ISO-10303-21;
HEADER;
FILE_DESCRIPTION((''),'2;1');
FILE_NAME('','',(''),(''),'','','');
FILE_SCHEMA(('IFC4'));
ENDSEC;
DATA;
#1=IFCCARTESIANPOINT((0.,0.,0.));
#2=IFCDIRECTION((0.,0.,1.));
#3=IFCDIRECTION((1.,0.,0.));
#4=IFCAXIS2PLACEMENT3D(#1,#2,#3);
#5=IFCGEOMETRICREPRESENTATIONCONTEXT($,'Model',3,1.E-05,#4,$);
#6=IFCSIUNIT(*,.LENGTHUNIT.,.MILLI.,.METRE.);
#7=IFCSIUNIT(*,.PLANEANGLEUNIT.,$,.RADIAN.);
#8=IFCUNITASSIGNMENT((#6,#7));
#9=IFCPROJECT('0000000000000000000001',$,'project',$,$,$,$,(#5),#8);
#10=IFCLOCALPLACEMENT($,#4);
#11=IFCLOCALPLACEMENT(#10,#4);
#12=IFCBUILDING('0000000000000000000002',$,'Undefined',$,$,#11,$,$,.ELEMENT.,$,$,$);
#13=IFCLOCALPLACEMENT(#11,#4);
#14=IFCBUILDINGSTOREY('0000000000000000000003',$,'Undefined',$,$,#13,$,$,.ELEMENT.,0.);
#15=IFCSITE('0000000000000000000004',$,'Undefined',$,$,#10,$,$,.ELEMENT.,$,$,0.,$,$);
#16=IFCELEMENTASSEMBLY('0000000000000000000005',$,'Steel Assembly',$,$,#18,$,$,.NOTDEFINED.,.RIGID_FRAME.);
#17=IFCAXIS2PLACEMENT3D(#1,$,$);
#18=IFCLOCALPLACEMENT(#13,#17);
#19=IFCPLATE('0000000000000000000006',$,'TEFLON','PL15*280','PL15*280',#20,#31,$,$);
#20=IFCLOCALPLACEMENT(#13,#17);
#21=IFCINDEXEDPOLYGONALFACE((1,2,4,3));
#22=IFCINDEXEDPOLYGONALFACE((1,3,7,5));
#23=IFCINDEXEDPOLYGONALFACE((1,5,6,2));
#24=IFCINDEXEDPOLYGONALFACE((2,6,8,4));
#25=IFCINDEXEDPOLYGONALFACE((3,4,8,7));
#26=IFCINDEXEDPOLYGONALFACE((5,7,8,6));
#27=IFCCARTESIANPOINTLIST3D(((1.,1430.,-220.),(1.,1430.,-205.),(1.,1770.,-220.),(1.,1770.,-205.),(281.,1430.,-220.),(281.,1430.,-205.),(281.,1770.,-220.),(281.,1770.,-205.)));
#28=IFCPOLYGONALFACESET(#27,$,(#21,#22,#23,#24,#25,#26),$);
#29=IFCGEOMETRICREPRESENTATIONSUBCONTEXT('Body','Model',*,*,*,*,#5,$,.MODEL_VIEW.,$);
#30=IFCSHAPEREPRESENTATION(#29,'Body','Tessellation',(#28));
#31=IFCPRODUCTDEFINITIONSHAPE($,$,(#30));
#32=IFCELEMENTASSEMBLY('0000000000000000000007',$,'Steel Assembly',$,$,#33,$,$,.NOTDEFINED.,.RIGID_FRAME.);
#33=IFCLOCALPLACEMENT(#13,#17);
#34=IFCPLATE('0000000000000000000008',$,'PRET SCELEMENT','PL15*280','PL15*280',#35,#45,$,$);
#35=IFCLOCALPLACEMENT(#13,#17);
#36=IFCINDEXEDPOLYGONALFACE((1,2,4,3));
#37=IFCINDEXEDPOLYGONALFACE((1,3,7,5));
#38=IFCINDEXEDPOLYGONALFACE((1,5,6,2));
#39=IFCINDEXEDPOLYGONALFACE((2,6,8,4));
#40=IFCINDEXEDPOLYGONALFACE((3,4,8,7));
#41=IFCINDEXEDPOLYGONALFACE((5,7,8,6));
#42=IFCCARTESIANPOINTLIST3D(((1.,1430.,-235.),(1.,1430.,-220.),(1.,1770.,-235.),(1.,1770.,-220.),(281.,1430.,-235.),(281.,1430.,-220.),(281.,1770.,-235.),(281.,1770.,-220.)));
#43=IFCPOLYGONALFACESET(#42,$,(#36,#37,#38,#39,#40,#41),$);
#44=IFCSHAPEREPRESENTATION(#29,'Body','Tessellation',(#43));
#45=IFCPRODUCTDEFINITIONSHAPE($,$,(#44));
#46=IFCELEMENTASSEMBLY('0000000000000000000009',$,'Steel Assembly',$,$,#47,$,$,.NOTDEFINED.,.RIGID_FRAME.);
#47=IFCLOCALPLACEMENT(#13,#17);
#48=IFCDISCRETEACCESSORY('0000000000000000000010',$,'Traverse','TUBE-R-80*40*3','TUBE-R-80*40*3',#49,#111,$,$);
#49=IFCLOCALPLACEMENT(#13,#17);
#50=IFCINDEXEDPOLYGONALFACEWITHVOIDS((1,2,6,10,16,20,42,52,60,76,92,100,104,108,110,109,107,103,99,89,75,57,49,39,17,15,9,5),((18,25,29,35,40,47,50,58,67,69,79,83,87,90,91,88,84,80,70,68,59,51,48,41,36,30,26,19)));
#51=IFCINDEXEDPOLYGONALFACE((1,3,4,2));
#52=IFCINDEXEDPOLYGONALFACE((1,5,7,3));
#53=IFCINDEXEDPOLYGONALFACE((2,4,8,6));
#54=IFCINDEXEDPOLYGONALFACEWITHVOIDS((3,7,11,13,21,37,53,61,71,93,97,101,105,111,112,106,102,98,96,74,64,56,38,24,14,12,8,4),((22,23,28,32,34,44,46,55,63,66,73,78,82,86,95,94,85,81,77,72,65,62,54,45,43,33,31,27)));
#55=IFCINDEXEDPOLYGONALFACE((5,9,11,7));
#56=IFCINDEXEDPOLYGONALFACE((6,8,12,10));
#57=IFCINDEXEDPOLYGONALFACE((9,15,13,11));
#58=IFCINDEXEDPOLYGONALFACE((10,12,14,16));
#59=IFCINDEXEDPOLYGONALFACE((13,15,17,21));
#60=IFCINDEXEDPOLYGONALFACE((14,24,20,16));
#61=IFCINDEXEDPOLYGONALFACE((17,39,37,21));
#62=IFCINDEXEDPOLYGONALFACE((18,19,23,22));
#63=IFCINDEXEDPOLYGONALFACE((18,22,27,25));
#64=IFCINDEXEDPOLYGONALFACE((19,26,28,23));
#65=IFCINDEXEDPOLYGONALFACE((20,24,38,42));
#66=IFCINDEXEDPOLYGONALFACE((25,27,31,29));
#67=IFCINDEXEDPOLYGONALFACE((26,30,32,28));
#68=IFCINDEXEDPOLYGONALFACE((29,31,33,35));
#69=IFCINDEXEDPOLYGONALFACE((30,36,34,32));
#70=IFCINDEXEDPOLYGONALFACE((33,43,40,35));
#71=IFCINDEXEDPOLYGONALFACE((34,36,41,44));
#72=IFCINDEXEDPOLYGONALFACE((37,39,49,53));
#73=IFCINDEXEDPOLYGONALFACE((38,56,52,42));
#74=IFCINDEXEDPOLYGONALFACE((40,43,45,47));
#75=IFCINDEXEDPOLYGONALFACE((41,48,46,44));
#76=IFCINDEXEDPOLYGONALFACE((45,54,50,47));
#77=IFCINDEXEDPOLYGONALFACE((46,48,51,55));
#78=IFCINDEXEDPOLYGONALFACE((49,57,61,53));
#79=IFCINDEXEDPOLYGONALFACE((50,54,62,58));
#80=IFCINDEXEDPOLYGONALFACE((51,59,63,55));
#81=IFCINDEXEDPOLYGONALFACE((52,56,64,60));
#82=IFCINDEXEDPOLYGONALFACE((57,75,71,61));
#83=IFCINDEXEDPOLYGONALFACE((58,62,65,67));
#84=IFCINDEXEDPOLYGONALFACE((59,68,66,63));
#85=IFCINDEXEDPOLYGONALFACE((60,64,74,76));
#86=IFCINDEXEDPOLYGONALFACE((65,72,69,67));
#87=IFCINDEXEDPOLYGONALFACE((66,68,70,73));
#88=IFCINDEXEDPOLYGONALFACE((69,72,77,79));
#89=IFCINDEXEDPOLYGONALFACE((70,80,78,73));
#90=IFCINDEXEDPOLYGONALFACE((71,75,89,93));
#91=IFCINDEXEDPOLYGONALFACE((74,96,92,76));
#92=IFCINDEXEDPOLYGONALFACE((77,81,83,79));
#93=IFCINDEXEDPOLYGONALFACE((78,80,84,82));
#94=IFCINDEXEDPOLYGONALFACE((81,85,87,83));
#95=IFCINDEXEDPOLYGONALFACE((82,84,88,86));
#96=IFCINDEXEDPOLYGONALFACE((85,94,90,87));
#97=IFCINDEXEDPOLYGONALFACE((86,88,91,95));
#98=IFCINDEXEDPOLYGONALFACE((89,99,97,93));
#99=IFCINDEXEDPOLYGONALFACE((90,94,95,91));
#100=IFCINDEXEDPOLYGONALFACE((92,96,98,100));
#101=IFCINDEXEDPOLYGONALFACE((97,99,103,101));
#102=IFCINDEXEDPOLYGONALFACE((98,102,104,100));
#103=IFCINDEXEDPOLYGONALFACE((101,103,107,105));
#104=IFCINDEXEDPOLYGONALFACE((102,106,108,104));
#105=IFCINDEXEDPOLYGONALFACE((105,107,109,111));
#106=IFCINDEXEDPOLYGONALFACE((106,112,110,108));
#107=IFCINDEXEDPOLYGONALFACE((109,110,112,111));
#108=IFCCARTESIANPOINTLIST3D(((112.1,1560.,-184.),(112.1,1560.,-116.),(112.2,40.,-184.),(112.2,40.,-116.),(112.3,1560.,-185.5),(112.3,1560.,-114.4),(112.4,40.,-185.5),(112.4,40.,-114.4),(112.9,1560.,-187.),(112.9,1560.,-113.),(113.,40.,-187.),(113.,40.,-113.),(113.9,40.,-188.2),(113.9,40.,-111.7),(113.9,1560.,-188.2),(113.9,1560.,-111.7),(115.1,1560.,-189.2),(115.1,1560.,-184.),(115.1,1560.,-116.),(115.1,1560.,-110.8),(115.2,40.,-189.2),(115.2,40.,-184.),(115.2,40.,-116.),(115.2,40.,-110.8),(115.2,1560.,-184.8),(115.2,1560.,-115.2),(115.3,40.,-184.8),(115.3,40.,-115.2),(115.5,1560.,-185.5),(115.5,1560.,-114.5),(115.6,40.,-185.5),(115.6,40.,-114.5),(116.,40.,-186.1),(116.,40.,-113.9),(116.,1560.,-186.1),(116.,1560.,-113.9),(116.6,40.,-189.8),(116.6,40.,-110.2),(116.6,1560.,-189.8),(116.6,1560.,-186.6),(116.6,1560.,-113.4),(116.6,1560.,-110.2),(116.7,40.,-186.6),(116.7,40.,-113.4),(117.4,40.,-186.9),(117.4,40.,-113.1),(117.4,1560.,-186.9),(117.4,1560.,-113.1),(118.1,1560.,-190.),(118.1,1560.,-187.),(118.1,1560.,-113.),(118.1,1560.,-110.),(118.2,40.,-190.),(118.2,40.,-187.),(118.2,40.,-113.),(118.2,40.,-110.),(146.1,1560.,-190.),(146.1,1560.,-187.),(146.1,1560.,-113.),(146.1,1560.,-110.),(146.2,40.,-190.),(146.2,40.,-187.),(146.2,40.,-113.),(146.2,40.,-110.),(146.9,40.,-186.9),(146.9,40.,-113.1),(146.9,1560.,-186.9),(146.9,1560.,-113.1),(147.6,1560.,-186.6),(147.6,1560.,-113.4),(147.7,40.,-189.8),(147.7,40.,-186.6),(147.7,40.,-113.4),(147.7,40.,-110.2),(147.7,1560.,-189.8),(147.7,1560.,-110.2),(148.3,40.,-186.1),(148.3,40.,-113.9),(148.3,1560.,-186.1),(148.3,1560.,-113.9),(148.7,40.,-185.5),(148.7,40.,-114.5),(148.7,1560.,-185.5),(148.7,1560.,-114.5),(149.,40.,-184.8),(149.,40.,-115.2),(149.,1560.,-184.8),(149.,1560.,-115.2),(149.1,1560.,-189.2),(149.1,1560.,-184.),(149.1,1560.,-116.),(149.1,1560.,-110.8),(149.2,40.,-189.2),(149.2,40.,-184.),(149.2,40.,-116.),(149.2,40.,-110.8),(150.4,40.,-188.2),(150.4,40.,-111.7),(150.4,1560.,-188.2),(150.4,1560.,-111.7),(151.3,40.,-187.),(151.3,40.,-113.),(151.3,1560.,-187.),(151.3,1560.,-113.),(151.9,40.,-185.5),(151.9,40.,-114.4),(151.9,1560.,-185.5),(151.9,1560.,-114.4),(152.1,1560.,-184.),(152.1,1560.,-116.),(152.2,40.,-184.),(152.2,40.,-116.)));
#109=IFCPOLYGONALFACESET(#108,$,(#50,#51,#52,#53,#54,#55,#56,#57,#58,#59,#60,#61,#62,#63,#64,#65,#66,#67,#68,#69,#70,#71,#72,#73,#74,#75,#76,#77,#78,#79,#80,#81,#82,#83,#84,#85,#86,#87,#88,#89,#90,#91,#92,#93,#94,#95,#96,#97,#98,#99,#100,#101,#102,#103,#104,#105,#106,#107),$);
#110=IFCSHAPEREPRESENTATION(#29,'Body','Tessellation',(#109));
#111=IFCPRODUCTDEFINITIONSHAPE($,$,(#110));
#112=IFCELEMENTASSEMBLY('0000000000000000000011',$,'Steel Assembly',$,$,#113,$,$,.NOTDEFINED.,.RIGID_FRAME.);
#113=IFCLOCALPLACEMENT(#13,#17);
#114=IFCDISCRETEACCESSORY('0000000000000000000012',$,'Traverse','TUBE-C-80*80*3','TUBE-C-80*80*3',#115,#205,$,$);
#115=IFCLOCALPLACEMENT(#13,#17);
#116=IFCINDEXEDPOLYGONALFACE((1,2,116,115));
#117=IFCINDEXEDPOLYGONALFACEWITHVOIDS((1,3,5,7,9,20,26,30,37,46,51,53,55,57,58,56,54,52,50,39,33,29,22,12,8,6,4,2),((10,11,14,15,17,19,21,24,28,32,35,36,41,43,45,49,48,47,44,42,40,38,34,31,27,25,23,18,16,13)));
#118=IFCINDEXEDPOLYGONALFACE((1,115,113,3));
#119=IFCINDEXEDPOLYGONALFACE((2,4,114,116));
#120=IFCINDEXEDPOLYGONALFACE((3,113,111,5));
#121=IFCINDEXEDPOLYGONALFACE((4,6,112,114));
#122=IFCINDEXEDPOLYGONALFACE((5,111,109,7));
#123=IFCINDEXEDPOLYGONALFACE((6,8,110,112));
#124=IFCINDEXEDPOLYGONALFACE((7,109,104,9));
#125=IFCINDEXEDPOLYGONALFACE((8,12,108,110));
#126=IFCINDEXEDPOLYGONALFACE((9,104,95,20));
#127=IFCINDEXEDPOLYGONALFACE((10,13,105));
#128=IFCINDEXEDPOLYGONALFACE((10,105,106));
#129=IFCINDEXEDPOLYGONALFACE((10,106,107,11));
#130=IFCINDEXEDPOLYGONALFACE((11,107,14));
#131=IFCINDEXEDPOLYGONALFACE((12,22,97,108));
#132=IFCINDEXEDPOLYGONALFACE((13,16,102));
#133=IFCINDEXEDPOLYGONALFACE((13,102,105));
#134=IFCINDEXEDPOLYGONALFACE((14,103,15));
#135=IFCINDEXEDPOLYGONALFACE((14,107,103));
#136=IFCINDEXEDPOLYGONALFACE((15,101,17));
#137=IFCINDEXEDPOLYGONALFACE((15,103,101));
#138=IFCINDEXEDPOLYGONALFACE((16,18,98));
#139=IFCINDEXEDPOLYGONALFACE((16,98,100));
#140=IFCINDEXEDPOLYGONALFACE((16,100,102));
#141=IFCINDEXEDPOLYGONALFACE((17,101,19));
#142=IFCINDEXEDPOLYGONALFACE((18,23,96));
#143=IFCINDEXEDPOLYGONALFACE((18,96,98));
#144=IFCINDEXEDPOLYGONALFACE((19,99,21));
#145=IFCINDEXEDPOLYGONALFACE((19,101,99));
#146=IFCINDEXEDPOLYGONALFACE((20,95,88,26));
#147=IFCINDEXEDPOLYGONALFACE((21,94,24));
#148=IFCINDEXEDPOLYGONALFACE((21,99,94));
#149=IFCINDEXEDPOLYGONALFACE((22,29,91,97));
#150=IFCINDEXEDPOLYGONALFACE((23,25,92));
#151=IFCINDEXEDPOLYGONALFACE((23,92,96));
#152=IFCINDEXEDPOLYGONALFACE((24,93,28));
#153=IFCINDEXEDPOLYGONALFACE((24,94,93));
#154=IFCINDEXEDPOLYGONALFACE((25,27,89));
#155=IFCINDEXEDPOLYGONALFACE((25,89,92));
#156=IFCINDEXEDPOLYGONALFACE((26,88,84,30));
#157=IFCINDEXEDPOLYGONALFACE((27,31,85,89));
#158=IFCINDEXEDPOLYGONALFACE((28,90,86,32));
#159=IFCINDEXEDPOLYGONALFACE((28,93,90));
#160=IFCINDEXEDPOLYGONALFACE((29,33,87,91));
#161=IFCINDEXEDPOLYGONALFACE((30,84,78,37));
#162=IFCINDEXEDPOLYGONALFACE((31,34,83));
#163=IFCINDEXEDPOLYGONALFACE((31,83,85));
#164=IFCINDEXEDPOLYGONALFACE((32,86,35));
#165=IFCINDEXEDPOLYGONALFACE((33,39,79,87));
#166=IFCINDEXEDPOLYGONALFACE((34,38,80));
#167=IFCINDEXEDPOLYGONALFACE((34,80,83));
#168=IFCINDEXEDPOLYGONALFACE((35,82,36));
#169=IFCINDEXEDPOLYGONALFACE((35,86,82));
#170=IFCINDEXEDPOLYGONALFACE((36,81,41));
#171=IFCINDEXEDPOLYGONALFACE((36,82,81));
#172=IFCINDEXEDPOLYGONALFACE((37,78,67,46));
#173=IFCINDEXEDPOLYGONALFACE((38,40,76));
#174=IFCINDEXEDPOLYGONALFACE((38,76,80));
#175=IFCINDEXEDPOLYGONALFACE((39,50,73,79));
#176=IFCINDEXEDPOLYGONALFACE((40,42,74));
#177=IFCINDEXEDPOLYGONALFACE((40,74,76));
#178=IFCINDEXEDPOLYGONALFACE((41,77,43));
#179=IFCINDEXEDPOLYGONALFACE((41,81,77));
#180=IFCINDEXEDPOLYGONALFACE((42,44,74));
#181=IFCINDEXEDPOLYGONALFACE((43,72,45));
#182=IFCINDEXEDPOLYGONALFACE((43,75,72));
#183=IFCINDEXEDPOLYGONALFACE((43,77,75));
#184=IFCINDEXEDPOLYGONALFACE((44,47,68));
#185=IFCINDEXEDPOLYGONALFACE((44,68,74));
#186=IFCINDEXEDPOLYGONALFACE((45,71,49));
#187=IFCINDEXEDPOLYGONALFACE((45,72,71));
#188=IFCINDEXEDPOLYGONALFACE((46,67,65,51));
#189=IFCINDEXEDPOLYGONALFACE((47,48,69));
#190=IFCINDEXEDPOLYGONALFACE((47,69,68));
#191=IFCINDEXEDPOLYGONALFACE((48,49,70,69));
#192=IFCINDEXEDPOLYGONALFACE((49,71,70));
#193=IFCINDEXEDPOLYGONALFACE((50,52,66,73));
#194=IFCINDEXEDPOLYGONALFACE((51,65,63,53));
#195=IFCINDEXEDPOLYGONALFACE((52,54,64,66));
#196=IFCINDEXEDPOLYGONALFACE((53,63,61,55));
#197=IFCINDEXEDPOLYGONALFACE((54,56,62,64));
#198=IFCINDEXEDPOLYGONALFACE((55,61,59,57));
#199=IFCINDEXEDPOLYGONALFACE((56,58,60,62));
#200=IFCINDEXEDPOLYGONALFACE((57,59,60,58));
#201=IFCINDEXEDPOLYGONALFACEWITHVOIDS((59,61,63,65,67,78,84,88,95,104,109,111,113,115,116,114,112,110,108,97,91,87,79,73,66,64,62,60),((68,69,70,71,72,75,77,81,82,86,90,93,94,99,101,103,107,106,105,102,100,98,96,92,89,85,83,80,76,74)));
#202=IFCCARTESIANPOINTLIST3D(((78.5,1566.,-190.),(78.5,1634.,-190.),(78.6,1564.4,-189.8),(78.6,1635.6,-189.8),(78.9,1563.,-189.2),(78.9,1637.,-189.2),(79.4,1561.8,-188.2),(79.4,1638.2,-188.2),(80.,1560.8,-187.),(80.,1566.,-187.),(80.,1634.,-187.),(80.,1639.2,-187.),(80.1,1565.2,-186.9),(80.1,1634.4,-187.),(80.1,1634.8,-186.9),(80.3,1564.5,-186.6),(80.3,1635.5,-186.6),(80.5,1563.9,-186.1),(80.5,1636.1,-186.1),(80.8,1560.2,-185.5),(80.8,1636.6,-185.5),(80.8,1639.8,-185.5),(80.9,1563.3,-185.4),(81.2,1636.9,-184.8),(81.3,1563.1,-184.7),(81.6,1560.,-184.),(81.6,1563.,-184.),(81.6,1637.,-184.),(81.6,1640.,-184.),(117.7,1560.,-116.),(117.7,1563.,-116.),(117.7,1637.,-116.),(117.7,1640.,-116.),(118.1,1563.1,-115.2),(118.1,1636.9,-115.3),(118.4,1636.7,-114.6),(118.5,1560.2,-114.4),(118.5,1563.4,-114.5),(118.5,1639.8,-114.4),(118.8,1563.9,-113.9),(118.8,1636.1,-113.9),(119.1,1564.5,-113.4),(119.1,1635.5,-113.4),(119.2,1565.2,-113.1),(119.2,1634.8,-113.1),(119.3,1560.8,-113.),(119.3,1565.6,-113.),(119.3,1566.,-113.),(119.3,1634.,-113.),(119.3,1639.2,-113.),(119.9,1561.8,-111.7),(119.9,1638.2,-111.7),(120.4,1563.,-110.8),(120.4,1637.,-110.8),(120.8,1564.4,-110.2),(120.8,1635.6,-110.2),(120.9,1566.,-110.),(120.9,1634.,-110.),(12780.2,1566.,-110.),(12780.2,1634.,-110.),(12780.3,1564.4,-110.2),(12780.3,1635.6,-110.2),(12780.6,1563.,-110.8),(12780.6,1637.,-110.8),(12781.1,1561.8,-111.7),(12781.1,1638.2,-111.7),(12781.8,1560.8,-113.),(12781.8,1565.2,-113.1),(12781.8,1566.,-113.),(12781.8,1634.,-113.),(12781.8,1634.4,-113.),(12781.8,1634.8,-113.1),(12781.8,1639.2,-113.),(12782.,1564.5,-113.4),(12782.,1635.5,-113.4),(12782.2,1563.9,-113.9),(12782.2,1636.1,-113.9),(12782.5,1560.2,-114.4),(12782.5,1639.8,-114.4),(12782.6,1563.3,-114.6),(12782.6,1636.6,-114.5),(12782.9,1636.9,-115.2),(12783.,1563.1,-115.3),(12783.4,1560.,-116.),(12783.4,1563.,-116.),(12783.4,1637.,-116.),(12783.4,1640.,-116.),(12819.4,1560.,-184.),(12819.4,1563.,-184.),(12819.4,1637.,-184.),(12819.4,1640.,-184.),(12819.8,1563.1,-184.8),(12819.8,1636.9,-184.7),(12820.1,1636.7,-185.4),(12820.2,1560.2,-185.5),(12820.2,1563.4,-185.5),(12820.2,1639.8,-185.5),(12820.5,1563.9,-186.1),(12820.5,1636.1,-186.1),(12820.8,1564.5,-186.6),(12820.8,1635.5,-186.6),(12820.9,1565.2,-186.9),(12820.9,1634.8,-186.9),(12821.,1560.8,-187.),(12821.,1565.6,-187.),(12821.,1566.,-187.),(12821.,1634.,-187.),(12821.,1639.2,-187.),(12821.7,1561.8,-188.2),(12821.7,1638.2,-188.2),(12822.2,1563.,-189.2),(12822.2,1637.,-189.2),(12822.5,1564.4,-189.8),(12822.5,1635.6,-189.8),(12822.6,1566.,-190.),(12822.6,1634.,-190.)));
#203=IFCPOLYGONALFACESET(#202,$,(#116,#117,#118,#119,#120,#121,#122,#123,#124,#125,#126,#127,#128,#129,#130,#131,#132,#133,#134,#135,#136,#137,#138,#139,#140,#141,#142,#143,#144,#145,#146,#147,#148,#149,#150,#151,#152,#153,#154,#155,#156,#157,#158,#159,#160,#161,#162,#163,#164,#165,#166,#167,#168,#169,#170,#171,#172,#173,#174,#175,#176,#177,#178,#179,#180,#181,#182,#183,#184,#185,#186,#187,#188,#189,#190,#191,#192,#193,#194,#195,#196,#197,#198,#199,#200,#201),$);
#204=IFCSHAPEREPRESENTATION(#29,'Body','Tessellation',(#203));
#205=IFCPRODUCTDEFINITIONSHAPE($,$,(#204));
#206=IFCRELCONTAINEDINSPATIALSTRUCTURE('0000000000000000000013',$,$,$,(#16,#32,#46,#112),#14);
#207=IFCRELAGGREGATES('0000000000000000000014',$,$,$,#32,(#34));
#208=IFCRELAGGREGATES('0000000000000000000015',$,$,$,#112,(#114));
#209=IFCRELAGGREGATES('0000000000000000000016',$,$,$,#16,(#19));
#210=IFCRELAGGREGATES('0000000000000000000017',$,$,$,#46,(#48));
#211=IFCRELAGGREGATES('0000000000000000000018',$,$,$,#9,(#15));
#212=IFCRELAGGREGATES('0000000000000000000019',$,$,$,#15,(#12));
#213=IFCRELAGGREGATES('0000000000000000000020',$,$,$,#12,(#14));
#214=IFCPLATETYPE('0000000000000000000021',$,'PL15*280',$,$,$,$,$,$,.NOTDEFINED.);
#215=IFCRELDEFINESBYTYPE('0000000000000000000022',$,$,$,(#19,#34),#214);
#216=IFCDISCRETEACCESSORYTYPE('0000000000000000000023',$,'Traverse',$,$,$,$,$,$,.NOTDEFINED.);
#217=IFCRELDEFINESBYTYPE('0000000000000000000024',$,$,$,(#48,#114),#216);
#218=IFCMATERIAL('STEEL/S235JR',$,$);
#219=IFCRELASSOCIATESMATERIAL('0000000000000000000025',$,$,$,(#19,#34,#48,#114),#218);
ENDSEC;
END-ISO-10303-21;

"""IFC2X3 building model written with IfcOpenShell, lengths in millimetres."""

from ifc_helpers import new_model, si_unit, frame, origin_with_axes, origin_2d_with_axis, place, context, subcontext, project, spatial, polyline, hollow_rectangle, outline, extrude, clip, halfspace, material, type_object, element, aggregate, save


model = new_model("IFC2X3")

# Units and contexts
model_context = context("Model", 3, precision=1e-05, world=origin_with_axes())
body_context = subcontext(model_context, "Body", "Model", "MODEL_VIEW")
ifc_project = project(units=[si_unit("LENGTHUNIT", "METRE", prefix="MILLI"), si_unit("PLANEANGLEUNIT", "RADIAN")], contexts=[model_context])

# Site, building, storey
site_placement = place(None, origin_with_axes())
site = spatial("IfcSite", under=ifc_project, at=site_placement, Name="Undefined", CompositionType="ELEMENT", RefElevation=0.0)
building_placement = place(site_placement, origin_with_axes())
building = spatial("IfcBuilding", under=site, at=building_placement, Name="Undefined", CompositionType="ELEMENT")
storey_placement = place(building_placement, origin_with_axes())
storey = spatial("IfcBuildingStorey", under=building, at=storey_placement, Name="Undefined", CompositionType="ELEMENT", Elevation=0.0)

# Element assemblies, plates
assembly_1_placement = place(storey_placement, origin_with_axes())
assembly_1 = element("IfcElementAssembly", 1, at=assembly_1_placement, inside=storey, Name="Steel Assembly", AssemblyPlace="NOTDEFINED", PredefinedType="RIGID_FRAME")
ifc_material_1 = material(Name="STEEL/S235JR")
plate_type = type_object("IfcPlateType", Name="PL15*280", PredefinedType="NOTDEFINED")
plate_1_placement = place(assembly_1_placement, frame((1.0, 1770.0, -212.5), z_axis=(0.0, 0.0, 1.0), x_axis=(0.000005, -1.0, 0.0)))
plate_1 = element("IfcPlate", 2, at=plate_1_placement, type_object=plate_type, material=ifc_material_1, Name="TEFLON", Description="PL15*280", ObjectType="PL15*280", context=body_context, shape_type="SweptSolid", body=[
    extrude(outline(polyline([(0.0, 0.0), (340.0, 0.0), (340.0, 280.0), (0.0, 280.0), (0.0, 0.0)])), frame((0.0, 0.0, -7.5), z_axis=(0.0, 0.0, 1.0), x_axis=(1.0, 0.0, 0.0)), (0.0, 0.0, 1.0), 15.0),
])
assembly_2_placement = place(storey_placement, origin_with_axes())
assembly_2 = element("IfcElementAssembly", 3, at=assembly_2_placement, inside=storey, Name="Steel Assembly", AssemblyPlace="NOTDEFINED", PredefinedType="RIGID_FRAME")
plate_2_placement = place(assembly_2_placement, frame((1.0, 1770.0, -227.5), z_axis=(0.0, 0.0, 1.0), x_axis=(0.000005, -1.0, 0.0)))
plate_2 = element("IfcPlate", 4, at=plate_2_placement, type_object=plate_type, material=ifc_material_1, Name="PRET SCELEMENT", Description="PL15*280", ObjectType="PL15*280", context=body_context, shape_type="SweptSolid", body=[
    extrude(outline(polyline([(0.0, 0.0), (340.0, 0.0), (340.0, 280.0), (0.0, 280.0), (0.0, 0.0)])), frame((0.0, 0.0, -7.5), z_axis=(0.0, 0.0, 1.0), x_axis=(1.0, 0.0, 0.0)), (0.0, 0.0, 1.0), 15.0),
])

# Element assemblies, discrete accessories
assembly_3_placement = place(storey_placement, origin_with_axes())
assembly_3 = element("IfcElementAssembly", 5, at=assembly_3_placement, inside=storey, Name="Steel Assembly", AssemblyPlace="NOTDEFINED", PredefinedType="RIGID_FRAME")
discrete_accessory_type_1 = type_object("IfcDiscreteAccessoryType", Name="Traverse")
discrete_accessory_1_placement = place(assembly_3_placement, frame((132.1, 1560.0, -150.0), z_axis=(0.0, 0.0, 1.0), x_axis=(0.000005, -1.0, 0.0)))
discrete_accessory_1 = element("IfcDiscreteAccessory", 6, at=discrete_accessory_1_placement, type_object=discrete_accessory_type_1, material=ifc_material_1, Name="Traverse", Description="TUBE-R-80*40*3", ObjectType="TUBE-R-80*40*3", context=body_context, shape_type="SweptSolid", body=[
    extrude(hollow_rectangle(XDim=40.0, YDim=80.0, WallThickness=3.0, InnerFilletRadius=3.0, OuterFilletRadius=6.0, at=origin_2d_with_axis()), frame((1520.0, 0.0, 0.0), z_axis=(-1.0, 0.0, 0.0), x_axis=(0.0, -1.0, 0.0)), (0.0, 0.0, 1.0), 1520.0),
])
assembly_4_placement = place(storey_placement, origin_with_axes())
assembly_4 = element("IfcElementAssembly", 7, at=assembly_4_placement, inside=storey, Name="Steel Assembly", AssemblyPlace="NOTDEFINED", PredefinedType="RIGID_FRAME")
discrete_accessory_2_placement = place(assembly_4_placement, frame((56.8, 1600.0, -150.0), z_axis=(0.0, 1.0, 0.0), x_axis=(1.0, 0.0, 0.0)))
discrete_accessory_2 = element("IfcDiscreteAccessory", 8, at=discrete_accessory_2_placement, type_object=discrete_accessory_type_1, material=ifc_material_1, Name="Traverse", Description="TUBE-C-80*80*3", ObjectType="TUBE-C-80*80*3", context=body_context, shape_type="Clipping", body=[
    clip(clip(extrude(hollow_rectangle(XDim=80.0, YDim=80.0, WallThickness=3.0, InnerFilletRadius=3.0, OuterFilletRadius=6.0, at=origin_2d_with_axis()), frame((12787.4, 0.0, 0.0), z_axis=(-1.0, 0.0, 0.0), x_axis=(0.0, -1.0, 0.0)), (0.0, 0.0, 1.0), 12787.4), halfspace(frame((21.6, 40.0, -40.0), z_axis=(-0.883508, -0.468417, 0.0), x_axis=(0.0, 0.0, 1.0)), False)), halfspace(frame((12723.4, -40.0, -40.0), z_axis=(0.883508, -0.468417, 0.0), x_axis=(0.0, 0.0, 1.0)), False)),
])

aggregate(assembly_2, [plate_2])
aggregate(assembly_4, [discrete_accessory_2])

aggregate(assembly_1, [plate_1])

aggregate(assembly_3, [discrete_accessory_1])

save(model, "model.ifc")
